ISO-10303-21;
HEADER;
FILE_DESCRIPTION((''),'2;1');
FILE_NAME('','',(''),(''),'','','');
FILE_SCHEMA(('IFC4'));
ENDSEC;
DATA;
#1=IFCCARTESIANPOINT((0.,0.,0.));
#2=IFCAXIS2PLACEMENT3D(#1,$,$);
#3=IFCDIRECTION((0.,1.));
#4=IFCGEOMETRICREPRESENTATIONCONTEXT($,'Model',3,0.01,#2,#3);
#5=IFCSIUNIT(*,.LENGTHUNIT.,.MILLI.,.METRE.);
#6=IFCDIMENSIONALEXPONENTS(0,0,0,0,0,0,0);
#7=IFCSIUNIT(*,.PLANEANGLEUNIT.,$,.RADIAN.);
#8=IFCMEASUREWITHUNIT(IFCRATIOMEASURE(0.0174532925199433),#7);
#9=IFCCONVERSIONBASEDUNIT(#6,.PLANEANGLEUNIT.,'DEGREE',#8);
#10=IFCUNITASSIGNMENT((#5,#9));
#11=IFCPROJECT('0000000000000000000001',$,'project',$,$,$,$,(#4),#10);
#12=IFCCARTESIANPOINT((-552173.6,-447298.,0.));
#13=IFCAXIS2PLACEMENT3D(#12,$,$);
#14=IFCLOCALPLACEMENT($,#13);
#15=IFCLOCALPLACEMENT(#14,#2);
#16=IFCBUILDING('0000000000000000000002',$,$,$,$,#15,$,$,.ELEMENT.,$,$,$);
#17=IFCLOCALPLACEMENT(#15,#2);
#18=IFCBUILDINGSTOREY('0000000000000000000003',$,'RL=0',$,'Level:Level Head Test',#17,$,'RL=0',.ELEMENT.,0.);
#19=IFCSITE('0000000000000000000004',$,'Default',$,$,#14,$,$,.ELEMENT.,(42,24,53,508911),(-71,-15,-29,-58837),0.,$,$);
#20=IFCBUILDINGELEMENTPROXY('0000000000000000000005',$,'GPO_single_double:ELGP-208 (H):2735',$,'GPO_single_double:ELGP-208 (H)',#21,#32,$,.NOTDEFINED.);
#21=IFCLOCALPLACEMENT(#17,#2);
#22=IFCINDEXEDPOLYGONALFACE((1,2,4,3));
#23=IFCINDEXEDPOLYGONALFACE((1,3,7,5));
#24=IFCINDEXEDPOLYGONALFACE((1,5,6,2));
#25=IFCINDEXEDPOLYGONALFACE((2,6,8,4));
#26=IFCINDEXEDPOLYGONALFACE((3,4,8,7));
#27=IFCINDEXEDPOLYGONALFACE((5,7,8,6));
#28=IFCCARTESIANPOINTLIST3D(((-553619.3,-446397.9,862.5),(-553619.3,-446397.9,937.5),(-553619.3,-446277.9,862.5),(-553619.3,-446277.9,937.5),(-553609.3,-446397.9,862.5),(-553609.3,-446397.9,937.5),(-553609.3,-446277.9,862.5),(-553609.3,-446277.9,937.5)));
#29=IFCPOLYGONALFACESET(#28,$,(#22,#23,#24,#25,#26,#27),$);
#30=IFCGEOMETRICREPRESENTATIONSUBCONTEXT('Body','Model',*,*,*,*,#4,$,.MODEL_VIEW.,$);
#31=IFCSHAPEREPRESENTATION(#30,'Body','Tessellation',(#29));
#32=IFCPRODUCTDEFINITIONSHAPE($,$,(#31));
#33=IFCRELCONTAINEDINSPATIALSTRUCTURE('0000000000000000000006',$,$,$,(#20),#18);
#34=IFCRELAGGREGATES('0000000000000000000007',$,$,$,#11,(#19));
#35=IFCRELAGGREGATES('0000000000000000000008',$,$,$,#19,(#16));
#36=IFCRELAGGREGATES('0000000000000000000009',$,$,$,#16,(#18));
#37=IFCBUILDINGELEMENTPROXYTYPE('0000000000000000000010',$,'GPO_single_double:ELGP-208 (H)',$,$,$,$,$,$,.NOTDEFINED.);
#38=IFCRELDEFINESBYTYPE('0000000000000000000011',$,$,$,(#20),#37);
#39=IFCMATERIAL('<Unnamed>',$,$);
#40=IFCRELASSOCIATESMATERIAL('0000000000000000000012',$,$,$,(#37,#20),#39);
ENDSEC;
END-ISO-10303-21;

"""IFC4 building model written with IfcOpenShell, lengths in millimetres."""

from ifc_helpers import new_model, entity, si_unit, converted_unit, direction, frame, origin, place, context, subcontext, project, spatial, indexed_curve, outline, extrude, source, transform, mapped, material, type_object, type_shapes, element, save


model = new_model("IFC4")

# Units and contexts
model_context = context("Model", 3, precision=0.01, world=origin(), true_north=direction((0.0, 1.0)))
body_context = subcontext(model_context, "Body", "Model", "MODEL_VIEW")
ifc_project = project(units=[si_unit("LENGTHUNIT", "METRE", prefix="MILLI"), converted_unit("PLANEANGLEUNIT", "DEGREE", entity("IfcRatioMeasure", 0.0174532925199433), si_unit("PLANEANGLEUNIT", "RADIAN"), dimensions=[0, 0, 0, 0, 0, 0, 0])], contexts=[model_context])

# Site, building, storey
site_placement = place(None, frame((-552173.6, -447298.0, 0.0)))
site = spatial("IfcSite", under=ifc_project, at=site_placement, Name="Default", CompositionType="ELEMENT", RefLatitude=(42, 24, 53, 508911), RefLongitude=(-71, -15, -29, -58837), RefElevation=0.0)
building_placement = place(site_placement, origin())
building = spatial("IfcBuilding", under=site, at=building_placement, CompositionType="ELEMENT")
storey_placement = place(building_placement, origin())
storey = spatial("IfcBuildingStorey", under=building, at=storey_placement, Name="RL=0", ObjectType="Level:Level Head Test", LongName="RL=0", CompositionType="ELEMENT", Elevation=0.0)

# Shared definitions
ifc_material_1 = material(Name="<Unnamed>")

# Building element proxy
building_element_proxy_type_1 = type_object("IfcBuildingElementProxyType", Name="GPO_single_double:ELGP-208 (H)", PredefinedType="NOTDEFINED", material=ifc_material_1)
shared_shape_1 = source(origin(), body_context, "Body", "SweptSolid", [
    extrude(outline(indexed_curve([(-5.0, -60.0), (5.0, -60.0), (5.0, 60.0), (-5.0, 60.0), (-5.0, -60.0)], self_intersect=False)), frame((60.0, 5.0, 0.0), z_axis=(0.0, 0.0, 1.0), x_axis=(0.0, 1.0, 0.0)), (0.0, 0.0, 1.0), 75.0),
])
type_shapes(building_element_proxy_type_1, [shared_shape_1])
proxy_1_placement = place(storey_placement, frame((-553609.3, -446397.9, 862.5), z_axis=(0.0, 0.0, 1.0), x_axis=(0.0, 1.0, 0.0)))
element("IfcBuildingElementProxy", 1, at=proxy_1_placement, inside=storey, type_object=building_element_proxy_type_1, material=ifc_material_1, Name="GPO_single_double:ELGP-208 (H):2735", ObjectType="GPO_single_double:ELGP-208 (H)", PredefinedType="NOTDEFINED", context=body_context, shape_type="MappedRepresentation", body=[
    mapped(shared_shape_1, transform((0.0, 0.0, 0.0), scale=1.0)),
])

save(model, "model.ifc")
